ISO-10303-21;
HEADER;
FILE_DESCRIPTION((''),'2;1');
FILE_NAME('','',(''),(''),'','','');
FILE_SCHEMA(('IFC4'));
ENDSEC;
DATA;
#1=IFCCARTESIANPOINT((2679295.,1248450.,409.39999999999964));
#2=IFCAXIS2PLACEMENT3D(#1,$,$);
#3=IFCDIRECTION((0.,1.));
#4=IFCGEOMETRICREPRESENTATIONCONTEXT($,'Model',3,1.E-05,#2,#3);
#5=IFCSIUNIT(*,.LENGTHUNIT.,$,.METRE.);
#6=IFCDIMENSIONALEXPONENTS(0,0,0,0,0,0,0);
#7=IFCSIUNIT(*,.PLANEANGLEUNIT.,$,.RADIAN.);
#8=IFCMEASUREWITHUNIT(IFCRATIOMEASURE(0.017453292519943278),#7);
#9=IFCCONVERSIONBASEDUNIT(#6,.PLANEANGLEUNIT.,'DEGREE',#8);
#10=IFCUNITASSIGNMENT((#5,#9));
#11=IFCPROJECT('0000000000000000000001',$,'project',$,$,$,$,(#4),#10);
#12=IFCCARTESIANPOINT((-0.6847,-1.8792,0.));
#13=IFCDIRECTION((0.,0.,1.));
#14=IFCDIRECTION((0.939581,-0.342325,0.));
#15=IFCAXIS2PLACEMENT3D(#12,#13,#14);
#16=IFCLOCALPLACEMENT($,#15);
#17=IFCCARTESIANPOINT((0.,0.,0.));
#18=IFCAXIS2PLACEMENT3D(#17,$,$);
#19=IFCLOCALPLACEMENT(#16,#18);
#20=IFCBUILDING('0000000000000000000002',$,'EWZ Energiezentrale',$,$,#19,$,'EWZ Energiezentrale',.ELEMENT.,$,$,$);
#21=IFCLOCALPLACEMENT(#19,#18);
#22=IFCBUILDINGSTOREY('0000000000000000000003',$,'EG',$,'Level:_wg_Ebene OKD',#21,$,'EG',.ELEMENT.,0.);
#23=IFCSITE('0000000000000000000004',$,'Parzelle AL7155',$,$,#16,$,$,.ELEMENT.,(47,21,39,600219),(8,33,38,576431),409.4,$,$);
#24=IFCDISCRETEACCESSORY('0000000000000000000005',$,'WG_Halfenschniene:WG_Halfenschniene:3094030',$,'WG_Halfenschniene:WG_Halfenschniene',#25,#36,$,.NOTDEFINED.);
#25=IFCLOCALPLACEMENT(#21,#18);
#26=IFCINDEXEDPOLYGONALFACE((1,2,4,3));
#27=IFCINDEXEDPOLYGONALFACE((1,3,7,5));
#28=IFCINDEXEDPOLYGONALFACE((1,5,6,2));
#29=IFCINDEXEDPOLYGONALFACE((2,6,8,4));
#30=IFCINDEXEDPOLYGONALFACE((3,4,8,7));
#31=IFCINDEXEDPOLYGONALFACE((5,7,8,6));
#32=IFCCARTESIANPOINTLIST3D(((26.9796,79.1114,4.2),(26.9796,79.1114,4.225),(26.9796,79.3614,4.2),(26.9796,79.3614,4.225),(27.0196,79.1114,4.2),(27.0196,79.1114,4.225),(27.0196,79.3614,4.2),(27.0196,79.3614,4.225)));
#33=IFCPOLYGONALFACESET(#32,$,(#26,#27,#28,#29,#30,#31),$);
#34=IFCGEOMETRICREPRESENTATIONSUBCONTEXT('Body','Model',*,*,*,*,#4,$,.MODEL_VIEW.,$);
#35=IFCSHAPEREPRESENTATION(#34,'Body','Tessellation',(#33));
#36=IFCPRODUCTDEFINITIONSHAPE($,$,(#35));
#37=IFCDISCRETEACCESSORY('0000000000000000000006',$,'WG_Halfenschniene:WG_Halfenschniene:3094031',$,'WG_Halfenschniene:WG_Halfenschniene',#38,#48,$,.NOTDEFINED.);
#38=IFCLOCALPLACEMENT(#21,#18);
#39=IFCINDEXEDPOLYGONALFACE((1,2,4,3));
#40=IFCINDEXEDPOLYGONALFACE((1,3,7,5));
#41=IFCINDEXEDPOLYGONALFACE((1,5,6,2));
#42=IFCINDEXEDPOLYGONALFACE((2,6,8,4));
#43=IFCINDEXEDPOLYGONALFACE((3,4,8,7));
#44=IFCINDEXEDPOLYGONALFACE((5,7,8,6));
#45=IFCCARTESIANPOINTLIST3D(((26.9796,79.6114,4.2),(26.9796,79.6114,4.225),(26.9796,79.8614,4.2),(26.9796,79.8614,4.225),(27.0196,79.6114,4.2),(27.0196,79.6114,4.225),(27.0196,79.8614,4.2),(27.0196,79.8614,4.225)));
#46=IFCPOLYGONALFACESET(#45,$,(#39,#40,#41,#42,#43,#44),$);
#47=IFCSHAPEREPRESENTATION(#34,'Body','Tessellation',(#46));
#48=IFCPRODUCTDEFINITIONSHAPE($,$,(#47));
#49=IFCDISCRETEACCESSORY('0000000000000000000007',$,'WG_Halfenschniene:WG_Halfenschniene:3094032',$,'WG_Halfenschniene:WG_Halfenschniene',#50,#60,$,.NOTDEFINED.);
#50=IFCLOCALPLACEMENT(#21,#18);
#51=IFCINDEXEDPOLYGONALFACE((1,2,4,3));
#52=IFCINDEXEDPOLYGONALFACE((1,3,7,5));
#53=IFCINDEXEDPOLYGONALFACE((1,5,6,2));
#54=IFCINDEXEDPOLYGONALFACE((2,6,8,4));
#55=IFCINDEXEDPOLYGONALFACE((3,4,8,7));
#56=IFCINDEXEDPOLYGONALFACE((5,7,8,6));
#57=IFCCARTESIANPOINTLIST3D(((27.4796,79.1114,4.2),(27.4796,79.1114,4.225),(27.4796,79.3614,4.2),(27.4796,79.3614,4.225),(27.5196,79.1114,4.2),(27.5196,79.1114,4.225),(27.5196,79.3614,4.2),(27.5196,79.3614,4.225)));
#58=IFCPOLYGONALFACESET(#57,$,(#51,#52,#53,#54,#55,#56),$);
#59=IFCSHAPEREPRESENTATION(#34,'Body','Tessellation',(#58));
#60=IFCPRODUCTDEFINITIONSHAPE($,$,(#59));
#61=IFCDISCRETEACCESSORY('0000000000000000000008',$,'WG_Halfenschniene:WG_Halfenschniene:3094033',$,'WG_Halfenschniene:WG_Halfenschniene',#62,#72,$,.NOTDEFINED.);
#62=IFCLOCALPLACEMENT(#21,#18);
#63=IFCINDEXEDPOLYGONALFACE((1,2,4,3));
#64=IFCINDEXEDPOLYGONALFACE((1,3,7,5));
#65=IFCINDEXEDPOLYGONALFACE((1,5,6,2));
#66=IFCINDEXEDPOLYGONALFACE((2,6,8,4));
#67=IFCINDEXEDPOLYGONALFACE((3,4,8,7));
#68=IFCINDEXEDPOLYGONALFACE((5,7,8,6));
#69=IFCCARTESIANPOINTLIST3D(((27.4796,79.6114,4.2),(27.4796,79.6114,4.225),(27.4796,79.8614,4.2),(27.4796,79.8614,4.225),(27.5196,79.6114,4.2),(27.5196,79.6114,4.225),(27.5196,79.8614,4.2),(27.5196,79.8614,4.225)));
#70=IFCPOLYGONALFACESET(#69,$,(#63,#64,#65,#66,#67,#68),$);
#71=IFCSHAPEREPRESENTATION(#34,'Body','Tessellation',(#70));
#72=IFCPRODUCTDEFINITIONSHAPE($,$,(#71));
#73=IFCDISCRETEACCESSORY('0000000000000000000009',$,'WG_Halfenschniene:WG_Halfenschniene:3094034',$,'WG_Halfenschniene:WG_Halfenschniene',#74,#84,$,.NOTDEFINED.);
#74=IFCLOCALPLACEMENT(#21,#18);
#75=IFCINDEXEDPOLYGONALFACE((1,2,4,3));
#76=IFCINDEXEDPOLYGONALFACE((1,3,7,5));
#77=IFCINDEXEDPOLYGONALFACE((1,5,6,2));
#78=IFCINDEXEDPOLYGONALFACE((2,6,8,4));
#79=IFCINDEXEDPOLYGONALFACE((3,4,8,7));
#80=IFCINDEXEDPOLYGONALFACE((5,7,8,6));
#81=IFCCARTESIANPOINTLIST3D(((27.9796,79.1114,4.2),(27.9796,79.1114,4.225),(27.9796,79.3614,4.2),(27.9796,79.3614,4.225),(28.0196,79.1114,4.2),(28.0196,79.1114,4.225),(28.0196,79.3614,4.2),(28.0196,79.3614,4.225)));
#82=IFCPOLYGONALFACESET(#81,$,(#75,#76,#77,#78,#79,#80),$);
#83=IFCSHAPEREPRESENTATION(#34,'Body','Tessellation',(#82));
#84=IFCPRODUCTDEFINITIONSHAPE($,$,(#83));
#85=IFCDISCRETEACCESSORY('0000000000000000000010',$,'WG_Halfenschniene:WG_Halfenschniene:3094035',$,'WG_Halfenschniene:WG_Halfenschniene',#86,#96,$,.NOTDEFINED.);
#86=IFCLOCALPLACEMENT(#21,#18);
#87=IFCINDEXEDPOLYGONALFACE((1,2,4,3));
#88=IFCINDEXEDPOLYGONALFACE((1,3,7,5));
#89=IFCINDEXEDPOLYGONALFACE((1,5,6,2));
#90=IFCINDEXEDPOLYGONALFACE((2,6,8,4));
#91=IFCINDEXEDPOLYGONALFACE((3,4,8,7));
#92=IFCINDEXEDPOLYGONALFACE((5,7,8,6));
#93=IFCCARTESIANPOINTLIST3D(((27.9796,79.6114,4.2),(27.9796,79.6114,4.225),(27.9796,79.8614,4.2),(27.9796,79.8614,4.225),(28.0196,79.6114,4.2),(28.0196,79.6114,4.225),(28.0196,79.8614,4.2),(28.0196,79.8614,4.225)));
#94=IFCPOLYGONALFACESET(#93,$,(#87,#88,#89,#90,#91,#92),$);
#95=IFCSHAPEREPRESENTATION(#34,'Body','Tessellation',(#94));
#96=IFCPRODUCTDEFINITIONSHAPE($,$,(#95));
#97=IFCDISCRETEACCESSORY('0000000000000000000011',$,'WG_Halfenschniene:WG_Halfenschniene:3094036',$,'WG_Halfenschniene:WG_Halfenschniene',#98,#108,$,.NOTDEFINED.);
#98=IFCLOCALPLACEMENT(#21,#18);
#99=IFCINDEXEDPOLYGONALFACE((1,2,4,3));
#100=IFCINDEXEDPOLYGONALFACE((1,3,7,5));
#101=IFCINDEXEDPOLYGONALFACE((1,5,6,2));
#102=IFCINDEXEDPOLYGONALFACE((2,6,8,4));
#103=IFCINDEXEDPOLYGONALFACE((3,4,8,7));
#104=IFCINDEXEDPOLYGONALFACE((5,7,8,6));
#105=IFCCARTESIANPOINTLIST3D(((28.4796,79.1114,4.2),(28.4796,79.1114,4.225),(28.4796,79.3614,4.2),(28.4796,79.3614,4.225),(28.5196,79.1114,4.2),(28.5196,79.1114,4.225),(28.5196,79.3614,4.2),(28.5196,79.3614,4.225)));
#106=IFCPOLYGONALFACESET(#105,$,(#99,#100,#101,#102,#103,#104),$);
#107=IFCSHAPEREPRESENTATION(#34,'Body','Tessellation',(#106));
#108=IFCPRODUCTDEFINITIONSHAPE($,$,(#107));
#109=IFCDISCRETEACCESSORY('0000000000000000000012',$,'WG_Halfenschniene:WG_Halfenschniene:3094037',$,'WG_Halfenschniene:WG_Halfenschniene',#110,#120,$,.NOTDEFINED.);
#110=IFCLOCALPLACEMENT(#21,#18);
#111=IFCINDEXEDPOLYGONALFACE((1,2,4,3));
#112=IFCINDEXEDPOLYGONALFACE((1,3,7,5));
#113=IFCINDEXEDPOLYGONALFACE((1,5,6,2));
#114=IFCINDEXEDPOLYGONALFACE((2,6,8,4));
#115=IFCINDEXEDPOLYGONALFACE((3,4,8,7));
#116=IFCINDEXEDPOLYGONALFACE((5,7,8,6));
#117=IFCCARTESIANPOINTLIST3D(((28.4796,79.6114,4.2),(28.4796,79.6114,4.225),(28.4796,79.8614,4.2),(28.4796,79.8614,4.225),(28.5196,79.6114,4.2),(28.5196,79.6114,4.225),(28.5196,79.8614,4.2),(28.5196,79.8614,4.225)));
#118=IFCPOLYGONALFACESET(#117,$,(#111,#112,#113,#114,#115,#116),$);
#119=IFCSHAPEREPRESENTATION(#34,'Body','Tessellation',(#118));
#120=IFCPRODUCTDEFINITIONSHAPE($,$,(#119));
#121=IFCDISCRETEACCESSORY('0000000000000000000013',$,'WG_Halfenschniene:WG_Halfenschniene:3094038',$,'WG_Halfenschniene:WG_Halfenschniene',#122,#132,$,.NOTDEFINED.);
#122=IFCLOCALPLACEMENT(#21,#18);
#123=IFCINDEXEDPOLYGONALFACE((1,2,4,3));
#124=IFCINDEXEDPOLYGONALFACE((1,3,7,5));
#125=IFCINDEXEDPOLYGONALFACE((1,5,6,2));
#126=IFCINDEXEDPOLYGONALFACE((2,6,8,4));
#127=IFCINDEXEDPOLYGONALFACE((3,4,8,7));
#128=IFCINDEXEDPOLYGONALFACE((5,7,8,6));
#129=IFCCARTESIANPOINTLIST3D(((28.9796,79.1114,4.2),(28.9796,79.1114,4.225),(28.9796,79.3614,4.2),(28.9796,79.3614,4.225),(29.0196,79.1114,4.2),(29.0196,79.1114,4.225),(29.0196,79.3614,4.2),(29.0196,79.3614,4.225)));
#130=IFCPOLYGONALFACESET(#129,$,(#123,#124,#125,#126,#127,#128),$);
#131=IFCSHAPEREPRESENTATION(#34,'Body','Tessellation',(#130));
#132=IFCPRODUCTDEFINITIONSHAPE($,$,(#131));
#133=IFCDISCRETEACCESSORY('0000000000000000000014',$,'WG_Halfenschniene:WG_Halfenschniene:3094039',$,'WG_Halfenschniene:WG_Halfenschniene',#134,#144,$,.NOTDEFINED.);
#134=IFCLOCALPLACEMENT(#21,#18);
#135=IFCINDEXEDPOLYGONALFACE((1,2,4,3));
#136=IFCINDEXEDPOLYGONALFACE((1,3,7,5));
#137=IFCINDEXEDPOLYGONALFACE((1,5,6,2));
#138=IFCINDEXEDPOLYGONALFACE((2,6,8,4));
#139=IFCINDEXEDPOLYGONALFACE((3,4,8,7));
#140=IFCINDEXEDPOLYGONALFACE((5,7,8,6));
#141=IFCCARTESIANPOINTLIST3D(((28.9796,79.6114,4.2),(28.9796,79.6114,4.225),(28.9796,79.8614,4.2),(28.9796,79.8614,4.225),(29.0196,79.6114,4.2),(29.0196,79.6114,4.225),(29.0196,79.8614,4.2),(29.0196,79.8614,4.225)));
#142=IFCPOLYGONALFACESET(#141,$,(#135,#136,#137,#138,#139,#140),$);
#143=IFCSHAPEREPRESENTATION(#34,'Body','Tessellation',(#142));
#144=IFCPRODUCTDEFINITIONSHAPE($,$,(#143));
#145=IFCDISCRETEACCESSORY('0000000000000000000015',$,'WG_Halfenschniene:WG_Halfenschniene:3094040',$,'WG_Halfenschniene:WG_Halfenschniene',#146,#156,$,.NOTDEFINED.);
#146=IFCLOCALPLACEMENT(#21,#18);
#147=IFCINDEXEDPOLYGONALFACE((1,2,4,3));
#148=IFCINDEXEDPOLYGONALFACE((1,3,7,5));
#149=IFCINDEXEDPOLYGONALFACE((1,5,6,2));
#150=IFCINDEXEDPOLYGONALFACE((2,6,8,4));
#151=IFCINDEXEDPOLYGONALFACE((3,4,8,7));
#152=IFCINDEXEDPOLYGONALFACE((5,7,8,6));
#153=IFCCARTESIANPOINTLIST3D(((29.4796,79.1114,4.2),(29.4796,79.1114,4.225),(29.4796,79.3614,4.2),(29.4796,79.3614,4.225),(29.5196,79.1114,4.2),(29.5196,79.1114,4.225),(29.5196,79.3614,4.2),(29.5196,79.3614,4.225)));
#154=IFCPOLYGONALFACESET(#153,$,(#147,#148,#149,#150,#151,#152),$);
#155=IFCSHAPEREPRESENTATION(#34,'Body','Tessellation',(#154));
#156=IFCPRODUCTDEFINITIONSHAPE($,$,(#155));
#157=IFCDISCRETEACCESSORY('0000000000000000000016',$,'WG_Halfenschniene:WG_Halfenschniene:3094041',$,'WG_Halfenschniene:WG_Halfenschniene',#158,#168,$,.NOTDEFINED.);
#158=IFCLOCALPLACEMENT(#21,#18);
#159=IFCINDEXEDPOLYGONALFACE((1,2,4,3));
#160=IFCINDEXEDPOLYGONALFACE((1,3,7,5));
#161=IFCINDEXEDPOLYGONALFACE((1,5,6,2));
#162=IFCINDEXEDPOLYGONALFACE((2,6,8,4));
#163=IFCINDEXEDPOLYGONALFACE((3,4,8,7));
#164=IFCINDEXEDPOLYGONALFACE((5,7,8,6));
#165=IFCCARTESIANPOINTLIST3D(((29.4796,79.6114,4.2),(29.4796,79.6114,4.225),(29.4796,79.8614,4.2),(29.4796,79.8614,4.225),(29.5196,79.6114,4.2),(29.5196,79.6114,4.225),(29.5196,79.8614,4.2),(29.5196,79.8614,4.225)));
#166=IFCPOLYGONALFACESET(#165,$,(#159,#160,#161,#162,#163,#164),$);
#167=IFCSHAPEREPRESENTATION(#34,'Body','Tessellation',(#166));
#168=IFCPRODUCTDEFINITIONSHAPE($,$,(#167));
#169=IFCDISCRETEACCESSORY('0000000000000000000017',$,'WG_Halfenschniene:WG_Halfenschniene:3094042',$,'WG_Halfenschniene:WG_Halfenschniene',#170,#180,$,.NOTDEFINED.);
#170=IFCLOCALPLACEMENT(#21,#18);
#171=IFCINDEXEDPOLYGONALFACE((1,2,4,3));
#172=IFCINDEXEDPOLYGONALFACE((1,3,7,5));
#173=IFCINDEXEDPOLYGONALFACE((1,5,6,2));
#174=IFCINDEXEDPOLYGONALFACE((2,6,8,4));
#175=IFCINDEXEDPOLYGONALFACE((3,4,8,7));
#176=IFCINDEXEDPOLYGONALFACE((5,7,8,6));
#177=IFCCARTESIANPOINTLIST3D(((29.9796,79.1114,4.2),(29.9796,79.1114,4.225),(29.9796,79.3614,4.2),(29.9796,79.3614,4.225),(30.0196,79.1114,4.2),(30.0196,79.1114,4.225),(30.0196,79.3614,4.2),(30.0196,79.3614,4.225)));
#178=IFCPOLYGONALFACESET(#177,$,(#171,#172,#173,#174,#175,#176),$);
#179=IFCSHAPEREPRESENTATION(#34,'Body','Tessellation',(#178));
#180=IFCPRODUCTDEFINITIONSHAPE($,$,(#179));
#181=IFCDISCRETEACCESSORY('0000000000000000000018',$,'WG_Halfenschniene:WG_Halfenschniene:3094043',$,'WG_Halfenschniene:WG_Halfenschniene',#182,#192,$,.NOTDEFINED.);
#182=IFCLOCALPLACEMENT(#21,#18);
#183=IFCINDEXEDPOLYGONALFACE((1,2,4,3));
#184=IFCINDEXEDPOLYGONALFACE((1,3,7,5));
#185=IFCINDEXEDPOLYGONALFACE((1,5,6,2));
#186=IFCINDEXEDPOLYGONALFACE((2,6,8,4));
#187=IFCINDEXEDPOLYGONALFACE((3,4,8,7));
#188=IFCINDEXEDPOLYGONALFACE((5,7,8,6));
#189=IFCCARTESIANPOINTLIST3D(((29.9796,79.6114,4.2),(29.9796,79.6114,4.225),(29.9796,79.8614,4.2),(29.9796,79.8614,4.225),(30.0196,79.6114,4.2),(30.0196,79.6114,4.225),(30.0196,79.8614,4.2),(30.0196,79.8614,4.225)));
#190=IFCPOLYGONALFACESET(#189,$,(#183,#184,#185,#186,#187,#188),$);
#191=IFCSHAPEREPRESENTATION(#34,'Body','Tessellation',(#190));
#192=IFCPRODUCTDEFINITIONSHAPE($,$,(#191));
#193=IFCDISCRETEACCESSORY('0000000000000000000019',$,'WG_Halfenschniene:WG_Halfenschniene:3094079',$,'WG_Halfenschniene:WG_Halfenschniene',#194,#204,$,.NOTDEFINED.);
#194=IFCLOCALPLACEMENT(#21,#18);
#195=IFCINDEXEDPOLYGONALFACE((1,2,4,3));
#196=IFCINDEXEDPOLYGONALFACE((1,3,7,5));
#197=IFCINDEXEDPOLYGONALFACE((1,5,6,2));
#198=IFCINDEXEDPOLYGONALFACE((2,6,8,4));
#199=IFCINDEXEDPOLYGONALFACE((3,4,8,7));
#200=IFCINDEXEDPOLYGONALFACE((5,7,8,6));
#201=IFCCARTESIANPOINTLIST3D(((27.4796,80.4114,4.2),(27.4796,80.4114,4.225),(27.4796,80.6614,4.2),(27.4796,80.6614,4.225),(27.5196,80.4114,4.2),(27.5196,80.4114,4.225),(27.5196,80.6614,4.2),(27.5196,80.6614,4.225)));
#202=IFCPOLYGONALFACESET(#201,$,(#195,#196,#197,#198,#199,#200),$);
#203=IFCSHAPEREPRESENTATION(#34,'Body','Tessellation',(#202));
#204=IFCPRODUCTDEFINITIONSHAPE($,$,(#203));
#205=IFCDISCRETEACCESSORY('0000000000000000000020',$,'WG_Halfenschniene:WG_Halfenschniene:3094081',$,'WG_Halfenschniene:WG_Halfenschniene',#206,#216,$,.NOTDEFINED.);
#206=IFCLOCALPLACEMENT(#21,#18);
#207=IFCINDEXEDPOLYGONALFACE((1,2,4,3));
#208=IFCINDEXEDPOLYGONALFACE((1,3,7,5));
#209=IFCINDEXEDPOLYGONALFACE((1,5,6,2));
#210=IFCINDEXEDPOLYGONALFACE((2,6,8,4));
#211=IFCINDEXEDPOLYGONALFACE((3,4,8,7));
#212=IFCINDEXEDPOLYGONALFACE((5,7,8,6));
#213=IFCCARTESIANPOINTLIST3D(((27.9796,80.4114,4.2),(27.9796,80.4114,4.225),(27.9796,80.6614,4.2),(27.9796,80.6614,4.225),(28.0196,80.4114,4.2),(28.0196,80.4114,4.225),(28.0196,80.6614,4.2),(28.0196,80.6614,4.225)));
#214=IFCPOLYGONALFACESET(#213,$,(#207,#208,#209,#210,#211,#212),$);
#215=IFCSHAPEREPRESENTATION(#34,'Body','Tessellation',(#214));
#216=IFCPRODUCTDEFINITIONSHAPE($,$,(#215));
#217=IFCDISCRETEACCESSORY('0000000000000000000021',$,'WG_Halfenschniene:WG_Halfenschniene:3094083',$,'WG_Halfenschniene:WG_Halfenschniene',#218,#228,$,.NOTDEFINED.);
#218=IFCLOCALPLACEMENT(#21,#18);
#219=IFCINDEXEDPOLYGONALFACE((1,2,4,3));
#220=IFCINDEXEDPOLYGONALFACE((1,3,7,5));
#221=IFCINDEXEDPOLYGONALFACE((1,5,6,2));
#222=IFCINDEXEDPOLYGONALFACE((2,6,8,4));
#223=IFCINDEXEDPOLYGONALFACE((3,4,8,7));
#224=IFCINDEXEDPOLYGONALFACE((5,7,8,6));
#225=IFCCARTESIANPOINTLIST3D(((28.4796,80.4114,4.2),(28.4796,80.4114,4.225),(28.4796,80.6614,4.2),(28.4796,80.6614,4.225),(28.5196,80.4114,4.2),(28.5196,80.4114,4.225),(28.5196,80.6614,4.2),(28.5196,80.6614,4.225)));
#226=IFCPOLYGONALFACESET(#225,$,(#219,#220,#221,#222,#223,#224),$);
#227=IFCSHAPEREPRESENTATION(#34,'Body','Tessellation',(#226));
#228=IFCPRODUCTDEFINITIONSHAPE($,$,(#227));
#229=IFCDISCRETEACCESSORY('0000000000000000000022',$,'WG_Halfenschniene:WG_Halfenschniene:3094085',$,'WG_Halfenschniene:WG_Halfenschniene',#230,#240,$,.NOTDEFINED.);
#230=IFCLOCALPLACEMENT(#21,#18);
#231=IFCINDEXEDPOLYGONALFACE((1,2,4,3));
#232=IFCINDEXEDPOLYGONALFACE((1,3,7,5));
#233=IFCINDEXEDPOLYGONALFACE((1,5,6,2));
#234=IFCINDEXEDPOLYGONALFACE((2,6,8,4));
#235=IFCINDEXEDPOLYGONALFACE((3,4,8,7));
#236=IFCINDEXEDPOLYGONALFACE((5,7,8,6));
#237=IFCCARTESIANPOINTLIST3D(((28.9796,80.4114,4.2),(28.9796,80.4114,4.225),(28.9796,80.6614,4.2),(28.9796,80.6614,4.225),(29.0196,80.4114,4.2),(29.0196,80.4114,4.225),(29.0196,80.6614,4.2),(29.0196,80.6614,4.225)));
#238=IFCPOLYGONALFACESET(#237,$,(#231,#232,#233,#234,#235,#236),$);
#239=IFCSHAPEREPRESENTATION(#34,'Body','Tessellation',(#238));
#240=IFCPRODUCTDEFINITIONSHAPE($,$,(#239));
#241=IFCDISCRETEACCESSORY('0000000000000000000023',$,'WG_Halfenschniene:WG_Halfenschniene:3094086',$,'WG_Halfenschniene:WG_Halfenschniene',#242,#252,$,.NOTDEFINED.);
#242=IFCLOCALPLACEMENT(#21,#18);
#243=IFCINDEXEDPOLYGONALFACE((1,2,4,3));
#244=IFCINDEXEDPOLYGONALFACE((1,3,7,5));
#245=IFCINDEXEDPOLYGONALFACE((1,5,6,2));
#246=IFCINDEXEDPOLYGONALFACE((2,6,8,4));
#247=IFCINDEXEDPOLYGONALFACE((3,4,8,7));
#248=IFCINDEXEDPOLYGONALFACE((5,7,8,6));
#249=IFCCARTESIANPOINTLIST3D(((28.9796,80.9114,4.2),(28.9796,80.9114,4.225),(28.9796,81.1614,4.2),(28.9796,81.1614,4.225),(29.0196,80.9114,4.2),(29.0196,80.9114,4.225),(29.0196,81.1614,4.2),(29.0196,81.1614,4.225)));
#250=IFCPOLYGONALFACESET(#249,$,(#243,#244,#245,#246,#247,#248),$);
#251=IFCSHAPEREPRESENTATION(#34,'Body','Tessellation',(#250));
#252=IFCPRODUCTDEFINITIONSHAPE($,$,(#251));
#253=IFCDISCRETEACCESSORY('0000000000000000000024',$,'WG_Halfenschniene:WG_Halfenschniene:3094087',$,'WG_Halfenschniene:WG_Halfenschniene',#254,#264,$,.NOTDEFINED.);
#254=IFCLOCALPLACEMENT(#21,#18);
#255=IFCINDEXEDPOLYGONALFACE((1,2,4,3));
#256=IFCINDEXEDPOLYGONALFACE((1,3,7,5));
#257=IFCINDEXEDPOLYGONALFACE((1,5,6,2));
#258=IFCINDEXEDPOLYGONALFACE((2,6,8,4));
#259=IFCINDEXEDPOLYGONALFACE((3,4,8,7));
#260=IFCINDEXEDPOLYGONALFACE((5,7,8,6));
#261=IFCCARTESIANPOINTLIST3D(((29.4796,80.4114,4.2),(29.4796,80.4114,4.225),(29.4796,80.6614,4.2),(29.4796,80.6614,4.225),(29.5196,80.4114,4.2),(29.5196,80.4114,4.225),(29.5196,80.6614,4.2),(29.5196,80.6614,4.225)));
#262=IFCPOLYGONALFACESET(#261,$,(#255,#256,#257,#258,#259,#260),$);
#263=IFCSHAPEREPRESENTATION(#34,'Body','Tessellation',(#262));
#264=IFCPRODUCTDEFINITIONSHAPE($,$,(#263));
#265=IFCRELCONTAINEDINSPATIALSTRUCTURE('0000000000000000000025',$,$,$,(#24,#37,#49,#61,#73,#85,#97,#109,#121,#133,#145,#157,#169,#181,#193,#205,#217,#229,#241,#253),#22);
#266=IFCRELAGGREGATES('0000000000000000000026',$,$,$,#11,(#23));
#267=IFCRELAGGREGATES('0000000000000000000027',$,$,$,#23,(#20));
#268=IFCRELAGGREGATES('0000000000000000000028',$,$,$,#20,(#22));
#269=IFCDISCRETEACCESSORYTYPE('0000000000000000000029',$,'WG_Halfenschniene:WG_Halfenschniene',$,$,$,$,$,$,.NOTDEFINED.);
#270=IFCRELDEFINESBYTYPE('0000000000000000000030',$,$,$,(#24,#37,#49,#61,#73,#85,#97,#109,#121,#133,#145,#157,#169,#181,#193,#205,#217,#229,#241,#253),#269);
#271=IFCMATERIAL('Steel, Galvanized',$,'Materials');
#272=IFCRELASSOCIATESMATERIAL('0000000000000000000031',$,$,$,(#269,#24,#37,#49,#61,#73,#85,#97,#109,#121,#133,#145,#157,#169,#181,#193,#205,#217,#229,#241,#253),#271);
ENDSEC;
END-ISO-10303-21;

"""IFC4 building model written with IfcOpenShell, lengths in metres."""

from ifc_helpers import new_model, entity, si_unit, converted_unit, direction, frame, origin, place, context, subcontext, project, spatial, indexed_curve, outline, extrude, source, transform, mapped, material, type_object, element, save


model = new_model("IFC4")

# Units and contexts
model_context = context("Model", 3, precision=1e-05, world=frame((2679295.0, 1248450.0, 409.39999999999964)), true_north=direction((0.0, 1.0)))
body_context = subcontext(model_context, "Body", "Model", "MODEL_VIEW")
ifc_project = project(units=[si_unit("LENGTHUNIT", "METRE"), converted_unit("PLANEANGLEUNIT", "DEGREE", entity("IfcRatioMeasure", 0.017453292519943278), si_unit("PLANEANGLEUNIT", "RADIAN"), dimensions=[0, 0, 0, 0, 0, 0, 0])], contexts=[model_context])

# Site, building, storey
site_placement = place(None, frame((-0.6847, -1.8792, 0.0), z_axis=(0.0, 0.0, 1.0), x_axis=(0.939581, -0.342325, 0.0)))
site = spatial("IfcSite", under=ifc_project, at=site_placement, Name="Parzelle AL7155", CompositionType="ELEMENT", RefLatitude=(47, 21, 39, 600219), RefLongitude=(8, 33, 38, 576431), RefElevation=409.4)
building_placement = place(site_placement, origin())
building = spatial("IfcBuilding", under=site, at=building_placement, Name="EWZ Energiezentrale", LongName="EWZ Energiezentrale", CompositionType="ELEMENT")
storey_placement = place(building_placement, origin())
storey = spatial("IfcBuildingStorey", under=building, at=storey_placement, Name="EG", ObjectType="Level:_wg_Ebene OKD", LongName="EG", CompositionType="ELEMENT", Elevation=0.0)

# Discrete accessories
ifc_material = material(Name="Steel, Galvanized", Category="Materials")
discrete_accessory_type = type_object("IfcDiscreteAccessoryType", Name="WG_Halfenschniene:WG_Halfenschniene", PredefinedType="NOTDEFINED", material=ifc_material)
shared_shape = source(origin(), body_context, "Body", "SweptSolid", [
    extrude(outline(indexed_curve([(-0.125, -0.02), (0.125, -0.02), (0.125, 0.02), (-0.125, 0.02), (-0.125, -0.02)], self_intersect=False)), frame((0.125, 0.0, -0.0125)), (0.0, 0.0, 1.0), 0.025),
])
for number, where, z_axis, x_axis, name in (
    (1, (26.9996, 79.1114, 4.2125), (0.0, 0.0, -1.0), (0.0, 1.0, 0.0), "WG_Halfenschniene:WG_Halfenschniene:3094030"),
    (2, (26.9996, 79.6114, 4.2125), (0.0, 0.0, -1.0), (0.0, 1.0, 0.0), "WG_Halfenschniene:WG_Halfenschniene:3094031"),
    (3, (27.4996, 79.1114, 4.2125), (0.0, 0.0, -1.0), (0.0, 1.0, 0.0), "WG_Halfenschniene:WG_Halfenschniene:3094032"),
    (4, (27.4996, 79.6114, 4.2125), (0.0, 0.0, -1.0), (0.0, 1.0, 0.0), "WG_Halfenschniene:WG_Halfenschniene:3094033"),
    (5, (27.9996, 79.1114, 4.2125), (0.0, 0.0, -1.0), (0.0, 1.0, 0.0), "WG_Halfenschniene:WG_Halfenschniene:3094034"),
    (6, (27.9996, 79.6114, 4.2125), (0.0, 0.0, -1.0), (0.0, 1.0, 0.0), "WG_Halfenschniene:WG_Halfenschniene:3094035"),
    (7, (28.4996, 79.1114, 4.2125), (0.0, 0.0, -1.0), (0.0, 1.0, 0.0), "WG_Halfenschniene:WG_Halfenschniene:3094036"),
    (8, (28.4996, 79.6114, 4.2125), (0.0, 0.0, -1.0), (0.0, 1.0, 0.0), "WG_Halfenschniene:WG_Halfenschniene:3094037"),
    (9, (28.9996, 79.1114, 4.2125), (0.0, 0.0, -1.0), (0.0, 1.0, 0.0), "WG_Halfenschniene:WG_Halfenschniene:3094038"),
    (10, (28.9996, 79.6114, 4.2125), (0.0, 0.0, -1.0), (0.0, 1.0, 0.0), "WG_Halfenschniene:WG_Halfenschniene:3094039"),
    (11, (29.4996, 79.1114, 4.2125), (0.0, 0.0, -1.0), (0.0, 1.0, 0.0), "WG_Halfenschniene:WG_Halfenschniene:3094040"),
    (12, (29.4996, 79.6114, 4.2125), (0.0, 0.0, -1.0), (0.0, 1.0, 0.0), "WG_Halfenschniene:WG_Halfenschniene:3094041"),
    (13, (29.9996, 79.1114, 4.2125), (0.0, 0.0, -1.0), (0.0, 1.0, 0.0), "WG_Halfenschniene:WG_Halfenschniene:3094042"),
    (14, (29.9996, 79.6114, 4.2125), (0.0, 0.0, -1.0), (0.0, 1.0, 0.0), "WG_Halfenschniene:WG_Halfenschniene:3094043"),
    (15, (27.4996, 80.4114, 4.2125), (0.0, 0.0, -1.0), (0.0, 1.0, 0.0), "WG_Halfenschniene:WG_Halfenschniene:3094079"),
    (16, (27.9996, 80.4114, 4.2125), (0.0, 0.0, -1.0), (0.0, 1.0, 0.0), "WG_Halfenschniene:WG_Halfenschniene:3094081"),
    (17, (28.4996, 80.4114, 4.2125), (0.0, 0.0, -1.0), (0.0, 1.0, 0.0), "WG_Halfenschniene:WG_Halfenschniene:3094083"),
    (18, (28.9996, 80.4114, 4.2125), (0.0, 0.0, -1.0), (0.0, 1.0, 0.0), "WG_Halfenschniene:WG_Halfenschniene:3094085"),
    (19, (28.9996, 80.9114, 4.2125), (0.0, 0.0, -1.0), (0.0, 1.0, 0.0), "WG_Halfenschniene:WG_Halfenschniene:3094086"),
    (20, (29.4996, 80.4114, 4.2125), (0.0, 0.0, -1.0), (0.0, 1.0, 0.0), "WG_Halfenschniene:WG_Halfenschniene:3094087"),
):
    element("IfcDiscreteAccessory", number, at=place(storey_placement, frame(where, z_axis=z_axis, x_axis=x_axis)), inside=storey, type_object=discrete_accessory_type, material=ifc_material, Name=name, ObjectType="WG_Halfenschniene:WG_Halfenschniene", PredefinedType="NOTDEFINED", context=body_context, shape_type="MappedRepresentation", body=[
        mapped(shared_shape, transform((0.0, 0.0, 0.0), scale=1.0)),
    ])

save(model, "model.ifc")
